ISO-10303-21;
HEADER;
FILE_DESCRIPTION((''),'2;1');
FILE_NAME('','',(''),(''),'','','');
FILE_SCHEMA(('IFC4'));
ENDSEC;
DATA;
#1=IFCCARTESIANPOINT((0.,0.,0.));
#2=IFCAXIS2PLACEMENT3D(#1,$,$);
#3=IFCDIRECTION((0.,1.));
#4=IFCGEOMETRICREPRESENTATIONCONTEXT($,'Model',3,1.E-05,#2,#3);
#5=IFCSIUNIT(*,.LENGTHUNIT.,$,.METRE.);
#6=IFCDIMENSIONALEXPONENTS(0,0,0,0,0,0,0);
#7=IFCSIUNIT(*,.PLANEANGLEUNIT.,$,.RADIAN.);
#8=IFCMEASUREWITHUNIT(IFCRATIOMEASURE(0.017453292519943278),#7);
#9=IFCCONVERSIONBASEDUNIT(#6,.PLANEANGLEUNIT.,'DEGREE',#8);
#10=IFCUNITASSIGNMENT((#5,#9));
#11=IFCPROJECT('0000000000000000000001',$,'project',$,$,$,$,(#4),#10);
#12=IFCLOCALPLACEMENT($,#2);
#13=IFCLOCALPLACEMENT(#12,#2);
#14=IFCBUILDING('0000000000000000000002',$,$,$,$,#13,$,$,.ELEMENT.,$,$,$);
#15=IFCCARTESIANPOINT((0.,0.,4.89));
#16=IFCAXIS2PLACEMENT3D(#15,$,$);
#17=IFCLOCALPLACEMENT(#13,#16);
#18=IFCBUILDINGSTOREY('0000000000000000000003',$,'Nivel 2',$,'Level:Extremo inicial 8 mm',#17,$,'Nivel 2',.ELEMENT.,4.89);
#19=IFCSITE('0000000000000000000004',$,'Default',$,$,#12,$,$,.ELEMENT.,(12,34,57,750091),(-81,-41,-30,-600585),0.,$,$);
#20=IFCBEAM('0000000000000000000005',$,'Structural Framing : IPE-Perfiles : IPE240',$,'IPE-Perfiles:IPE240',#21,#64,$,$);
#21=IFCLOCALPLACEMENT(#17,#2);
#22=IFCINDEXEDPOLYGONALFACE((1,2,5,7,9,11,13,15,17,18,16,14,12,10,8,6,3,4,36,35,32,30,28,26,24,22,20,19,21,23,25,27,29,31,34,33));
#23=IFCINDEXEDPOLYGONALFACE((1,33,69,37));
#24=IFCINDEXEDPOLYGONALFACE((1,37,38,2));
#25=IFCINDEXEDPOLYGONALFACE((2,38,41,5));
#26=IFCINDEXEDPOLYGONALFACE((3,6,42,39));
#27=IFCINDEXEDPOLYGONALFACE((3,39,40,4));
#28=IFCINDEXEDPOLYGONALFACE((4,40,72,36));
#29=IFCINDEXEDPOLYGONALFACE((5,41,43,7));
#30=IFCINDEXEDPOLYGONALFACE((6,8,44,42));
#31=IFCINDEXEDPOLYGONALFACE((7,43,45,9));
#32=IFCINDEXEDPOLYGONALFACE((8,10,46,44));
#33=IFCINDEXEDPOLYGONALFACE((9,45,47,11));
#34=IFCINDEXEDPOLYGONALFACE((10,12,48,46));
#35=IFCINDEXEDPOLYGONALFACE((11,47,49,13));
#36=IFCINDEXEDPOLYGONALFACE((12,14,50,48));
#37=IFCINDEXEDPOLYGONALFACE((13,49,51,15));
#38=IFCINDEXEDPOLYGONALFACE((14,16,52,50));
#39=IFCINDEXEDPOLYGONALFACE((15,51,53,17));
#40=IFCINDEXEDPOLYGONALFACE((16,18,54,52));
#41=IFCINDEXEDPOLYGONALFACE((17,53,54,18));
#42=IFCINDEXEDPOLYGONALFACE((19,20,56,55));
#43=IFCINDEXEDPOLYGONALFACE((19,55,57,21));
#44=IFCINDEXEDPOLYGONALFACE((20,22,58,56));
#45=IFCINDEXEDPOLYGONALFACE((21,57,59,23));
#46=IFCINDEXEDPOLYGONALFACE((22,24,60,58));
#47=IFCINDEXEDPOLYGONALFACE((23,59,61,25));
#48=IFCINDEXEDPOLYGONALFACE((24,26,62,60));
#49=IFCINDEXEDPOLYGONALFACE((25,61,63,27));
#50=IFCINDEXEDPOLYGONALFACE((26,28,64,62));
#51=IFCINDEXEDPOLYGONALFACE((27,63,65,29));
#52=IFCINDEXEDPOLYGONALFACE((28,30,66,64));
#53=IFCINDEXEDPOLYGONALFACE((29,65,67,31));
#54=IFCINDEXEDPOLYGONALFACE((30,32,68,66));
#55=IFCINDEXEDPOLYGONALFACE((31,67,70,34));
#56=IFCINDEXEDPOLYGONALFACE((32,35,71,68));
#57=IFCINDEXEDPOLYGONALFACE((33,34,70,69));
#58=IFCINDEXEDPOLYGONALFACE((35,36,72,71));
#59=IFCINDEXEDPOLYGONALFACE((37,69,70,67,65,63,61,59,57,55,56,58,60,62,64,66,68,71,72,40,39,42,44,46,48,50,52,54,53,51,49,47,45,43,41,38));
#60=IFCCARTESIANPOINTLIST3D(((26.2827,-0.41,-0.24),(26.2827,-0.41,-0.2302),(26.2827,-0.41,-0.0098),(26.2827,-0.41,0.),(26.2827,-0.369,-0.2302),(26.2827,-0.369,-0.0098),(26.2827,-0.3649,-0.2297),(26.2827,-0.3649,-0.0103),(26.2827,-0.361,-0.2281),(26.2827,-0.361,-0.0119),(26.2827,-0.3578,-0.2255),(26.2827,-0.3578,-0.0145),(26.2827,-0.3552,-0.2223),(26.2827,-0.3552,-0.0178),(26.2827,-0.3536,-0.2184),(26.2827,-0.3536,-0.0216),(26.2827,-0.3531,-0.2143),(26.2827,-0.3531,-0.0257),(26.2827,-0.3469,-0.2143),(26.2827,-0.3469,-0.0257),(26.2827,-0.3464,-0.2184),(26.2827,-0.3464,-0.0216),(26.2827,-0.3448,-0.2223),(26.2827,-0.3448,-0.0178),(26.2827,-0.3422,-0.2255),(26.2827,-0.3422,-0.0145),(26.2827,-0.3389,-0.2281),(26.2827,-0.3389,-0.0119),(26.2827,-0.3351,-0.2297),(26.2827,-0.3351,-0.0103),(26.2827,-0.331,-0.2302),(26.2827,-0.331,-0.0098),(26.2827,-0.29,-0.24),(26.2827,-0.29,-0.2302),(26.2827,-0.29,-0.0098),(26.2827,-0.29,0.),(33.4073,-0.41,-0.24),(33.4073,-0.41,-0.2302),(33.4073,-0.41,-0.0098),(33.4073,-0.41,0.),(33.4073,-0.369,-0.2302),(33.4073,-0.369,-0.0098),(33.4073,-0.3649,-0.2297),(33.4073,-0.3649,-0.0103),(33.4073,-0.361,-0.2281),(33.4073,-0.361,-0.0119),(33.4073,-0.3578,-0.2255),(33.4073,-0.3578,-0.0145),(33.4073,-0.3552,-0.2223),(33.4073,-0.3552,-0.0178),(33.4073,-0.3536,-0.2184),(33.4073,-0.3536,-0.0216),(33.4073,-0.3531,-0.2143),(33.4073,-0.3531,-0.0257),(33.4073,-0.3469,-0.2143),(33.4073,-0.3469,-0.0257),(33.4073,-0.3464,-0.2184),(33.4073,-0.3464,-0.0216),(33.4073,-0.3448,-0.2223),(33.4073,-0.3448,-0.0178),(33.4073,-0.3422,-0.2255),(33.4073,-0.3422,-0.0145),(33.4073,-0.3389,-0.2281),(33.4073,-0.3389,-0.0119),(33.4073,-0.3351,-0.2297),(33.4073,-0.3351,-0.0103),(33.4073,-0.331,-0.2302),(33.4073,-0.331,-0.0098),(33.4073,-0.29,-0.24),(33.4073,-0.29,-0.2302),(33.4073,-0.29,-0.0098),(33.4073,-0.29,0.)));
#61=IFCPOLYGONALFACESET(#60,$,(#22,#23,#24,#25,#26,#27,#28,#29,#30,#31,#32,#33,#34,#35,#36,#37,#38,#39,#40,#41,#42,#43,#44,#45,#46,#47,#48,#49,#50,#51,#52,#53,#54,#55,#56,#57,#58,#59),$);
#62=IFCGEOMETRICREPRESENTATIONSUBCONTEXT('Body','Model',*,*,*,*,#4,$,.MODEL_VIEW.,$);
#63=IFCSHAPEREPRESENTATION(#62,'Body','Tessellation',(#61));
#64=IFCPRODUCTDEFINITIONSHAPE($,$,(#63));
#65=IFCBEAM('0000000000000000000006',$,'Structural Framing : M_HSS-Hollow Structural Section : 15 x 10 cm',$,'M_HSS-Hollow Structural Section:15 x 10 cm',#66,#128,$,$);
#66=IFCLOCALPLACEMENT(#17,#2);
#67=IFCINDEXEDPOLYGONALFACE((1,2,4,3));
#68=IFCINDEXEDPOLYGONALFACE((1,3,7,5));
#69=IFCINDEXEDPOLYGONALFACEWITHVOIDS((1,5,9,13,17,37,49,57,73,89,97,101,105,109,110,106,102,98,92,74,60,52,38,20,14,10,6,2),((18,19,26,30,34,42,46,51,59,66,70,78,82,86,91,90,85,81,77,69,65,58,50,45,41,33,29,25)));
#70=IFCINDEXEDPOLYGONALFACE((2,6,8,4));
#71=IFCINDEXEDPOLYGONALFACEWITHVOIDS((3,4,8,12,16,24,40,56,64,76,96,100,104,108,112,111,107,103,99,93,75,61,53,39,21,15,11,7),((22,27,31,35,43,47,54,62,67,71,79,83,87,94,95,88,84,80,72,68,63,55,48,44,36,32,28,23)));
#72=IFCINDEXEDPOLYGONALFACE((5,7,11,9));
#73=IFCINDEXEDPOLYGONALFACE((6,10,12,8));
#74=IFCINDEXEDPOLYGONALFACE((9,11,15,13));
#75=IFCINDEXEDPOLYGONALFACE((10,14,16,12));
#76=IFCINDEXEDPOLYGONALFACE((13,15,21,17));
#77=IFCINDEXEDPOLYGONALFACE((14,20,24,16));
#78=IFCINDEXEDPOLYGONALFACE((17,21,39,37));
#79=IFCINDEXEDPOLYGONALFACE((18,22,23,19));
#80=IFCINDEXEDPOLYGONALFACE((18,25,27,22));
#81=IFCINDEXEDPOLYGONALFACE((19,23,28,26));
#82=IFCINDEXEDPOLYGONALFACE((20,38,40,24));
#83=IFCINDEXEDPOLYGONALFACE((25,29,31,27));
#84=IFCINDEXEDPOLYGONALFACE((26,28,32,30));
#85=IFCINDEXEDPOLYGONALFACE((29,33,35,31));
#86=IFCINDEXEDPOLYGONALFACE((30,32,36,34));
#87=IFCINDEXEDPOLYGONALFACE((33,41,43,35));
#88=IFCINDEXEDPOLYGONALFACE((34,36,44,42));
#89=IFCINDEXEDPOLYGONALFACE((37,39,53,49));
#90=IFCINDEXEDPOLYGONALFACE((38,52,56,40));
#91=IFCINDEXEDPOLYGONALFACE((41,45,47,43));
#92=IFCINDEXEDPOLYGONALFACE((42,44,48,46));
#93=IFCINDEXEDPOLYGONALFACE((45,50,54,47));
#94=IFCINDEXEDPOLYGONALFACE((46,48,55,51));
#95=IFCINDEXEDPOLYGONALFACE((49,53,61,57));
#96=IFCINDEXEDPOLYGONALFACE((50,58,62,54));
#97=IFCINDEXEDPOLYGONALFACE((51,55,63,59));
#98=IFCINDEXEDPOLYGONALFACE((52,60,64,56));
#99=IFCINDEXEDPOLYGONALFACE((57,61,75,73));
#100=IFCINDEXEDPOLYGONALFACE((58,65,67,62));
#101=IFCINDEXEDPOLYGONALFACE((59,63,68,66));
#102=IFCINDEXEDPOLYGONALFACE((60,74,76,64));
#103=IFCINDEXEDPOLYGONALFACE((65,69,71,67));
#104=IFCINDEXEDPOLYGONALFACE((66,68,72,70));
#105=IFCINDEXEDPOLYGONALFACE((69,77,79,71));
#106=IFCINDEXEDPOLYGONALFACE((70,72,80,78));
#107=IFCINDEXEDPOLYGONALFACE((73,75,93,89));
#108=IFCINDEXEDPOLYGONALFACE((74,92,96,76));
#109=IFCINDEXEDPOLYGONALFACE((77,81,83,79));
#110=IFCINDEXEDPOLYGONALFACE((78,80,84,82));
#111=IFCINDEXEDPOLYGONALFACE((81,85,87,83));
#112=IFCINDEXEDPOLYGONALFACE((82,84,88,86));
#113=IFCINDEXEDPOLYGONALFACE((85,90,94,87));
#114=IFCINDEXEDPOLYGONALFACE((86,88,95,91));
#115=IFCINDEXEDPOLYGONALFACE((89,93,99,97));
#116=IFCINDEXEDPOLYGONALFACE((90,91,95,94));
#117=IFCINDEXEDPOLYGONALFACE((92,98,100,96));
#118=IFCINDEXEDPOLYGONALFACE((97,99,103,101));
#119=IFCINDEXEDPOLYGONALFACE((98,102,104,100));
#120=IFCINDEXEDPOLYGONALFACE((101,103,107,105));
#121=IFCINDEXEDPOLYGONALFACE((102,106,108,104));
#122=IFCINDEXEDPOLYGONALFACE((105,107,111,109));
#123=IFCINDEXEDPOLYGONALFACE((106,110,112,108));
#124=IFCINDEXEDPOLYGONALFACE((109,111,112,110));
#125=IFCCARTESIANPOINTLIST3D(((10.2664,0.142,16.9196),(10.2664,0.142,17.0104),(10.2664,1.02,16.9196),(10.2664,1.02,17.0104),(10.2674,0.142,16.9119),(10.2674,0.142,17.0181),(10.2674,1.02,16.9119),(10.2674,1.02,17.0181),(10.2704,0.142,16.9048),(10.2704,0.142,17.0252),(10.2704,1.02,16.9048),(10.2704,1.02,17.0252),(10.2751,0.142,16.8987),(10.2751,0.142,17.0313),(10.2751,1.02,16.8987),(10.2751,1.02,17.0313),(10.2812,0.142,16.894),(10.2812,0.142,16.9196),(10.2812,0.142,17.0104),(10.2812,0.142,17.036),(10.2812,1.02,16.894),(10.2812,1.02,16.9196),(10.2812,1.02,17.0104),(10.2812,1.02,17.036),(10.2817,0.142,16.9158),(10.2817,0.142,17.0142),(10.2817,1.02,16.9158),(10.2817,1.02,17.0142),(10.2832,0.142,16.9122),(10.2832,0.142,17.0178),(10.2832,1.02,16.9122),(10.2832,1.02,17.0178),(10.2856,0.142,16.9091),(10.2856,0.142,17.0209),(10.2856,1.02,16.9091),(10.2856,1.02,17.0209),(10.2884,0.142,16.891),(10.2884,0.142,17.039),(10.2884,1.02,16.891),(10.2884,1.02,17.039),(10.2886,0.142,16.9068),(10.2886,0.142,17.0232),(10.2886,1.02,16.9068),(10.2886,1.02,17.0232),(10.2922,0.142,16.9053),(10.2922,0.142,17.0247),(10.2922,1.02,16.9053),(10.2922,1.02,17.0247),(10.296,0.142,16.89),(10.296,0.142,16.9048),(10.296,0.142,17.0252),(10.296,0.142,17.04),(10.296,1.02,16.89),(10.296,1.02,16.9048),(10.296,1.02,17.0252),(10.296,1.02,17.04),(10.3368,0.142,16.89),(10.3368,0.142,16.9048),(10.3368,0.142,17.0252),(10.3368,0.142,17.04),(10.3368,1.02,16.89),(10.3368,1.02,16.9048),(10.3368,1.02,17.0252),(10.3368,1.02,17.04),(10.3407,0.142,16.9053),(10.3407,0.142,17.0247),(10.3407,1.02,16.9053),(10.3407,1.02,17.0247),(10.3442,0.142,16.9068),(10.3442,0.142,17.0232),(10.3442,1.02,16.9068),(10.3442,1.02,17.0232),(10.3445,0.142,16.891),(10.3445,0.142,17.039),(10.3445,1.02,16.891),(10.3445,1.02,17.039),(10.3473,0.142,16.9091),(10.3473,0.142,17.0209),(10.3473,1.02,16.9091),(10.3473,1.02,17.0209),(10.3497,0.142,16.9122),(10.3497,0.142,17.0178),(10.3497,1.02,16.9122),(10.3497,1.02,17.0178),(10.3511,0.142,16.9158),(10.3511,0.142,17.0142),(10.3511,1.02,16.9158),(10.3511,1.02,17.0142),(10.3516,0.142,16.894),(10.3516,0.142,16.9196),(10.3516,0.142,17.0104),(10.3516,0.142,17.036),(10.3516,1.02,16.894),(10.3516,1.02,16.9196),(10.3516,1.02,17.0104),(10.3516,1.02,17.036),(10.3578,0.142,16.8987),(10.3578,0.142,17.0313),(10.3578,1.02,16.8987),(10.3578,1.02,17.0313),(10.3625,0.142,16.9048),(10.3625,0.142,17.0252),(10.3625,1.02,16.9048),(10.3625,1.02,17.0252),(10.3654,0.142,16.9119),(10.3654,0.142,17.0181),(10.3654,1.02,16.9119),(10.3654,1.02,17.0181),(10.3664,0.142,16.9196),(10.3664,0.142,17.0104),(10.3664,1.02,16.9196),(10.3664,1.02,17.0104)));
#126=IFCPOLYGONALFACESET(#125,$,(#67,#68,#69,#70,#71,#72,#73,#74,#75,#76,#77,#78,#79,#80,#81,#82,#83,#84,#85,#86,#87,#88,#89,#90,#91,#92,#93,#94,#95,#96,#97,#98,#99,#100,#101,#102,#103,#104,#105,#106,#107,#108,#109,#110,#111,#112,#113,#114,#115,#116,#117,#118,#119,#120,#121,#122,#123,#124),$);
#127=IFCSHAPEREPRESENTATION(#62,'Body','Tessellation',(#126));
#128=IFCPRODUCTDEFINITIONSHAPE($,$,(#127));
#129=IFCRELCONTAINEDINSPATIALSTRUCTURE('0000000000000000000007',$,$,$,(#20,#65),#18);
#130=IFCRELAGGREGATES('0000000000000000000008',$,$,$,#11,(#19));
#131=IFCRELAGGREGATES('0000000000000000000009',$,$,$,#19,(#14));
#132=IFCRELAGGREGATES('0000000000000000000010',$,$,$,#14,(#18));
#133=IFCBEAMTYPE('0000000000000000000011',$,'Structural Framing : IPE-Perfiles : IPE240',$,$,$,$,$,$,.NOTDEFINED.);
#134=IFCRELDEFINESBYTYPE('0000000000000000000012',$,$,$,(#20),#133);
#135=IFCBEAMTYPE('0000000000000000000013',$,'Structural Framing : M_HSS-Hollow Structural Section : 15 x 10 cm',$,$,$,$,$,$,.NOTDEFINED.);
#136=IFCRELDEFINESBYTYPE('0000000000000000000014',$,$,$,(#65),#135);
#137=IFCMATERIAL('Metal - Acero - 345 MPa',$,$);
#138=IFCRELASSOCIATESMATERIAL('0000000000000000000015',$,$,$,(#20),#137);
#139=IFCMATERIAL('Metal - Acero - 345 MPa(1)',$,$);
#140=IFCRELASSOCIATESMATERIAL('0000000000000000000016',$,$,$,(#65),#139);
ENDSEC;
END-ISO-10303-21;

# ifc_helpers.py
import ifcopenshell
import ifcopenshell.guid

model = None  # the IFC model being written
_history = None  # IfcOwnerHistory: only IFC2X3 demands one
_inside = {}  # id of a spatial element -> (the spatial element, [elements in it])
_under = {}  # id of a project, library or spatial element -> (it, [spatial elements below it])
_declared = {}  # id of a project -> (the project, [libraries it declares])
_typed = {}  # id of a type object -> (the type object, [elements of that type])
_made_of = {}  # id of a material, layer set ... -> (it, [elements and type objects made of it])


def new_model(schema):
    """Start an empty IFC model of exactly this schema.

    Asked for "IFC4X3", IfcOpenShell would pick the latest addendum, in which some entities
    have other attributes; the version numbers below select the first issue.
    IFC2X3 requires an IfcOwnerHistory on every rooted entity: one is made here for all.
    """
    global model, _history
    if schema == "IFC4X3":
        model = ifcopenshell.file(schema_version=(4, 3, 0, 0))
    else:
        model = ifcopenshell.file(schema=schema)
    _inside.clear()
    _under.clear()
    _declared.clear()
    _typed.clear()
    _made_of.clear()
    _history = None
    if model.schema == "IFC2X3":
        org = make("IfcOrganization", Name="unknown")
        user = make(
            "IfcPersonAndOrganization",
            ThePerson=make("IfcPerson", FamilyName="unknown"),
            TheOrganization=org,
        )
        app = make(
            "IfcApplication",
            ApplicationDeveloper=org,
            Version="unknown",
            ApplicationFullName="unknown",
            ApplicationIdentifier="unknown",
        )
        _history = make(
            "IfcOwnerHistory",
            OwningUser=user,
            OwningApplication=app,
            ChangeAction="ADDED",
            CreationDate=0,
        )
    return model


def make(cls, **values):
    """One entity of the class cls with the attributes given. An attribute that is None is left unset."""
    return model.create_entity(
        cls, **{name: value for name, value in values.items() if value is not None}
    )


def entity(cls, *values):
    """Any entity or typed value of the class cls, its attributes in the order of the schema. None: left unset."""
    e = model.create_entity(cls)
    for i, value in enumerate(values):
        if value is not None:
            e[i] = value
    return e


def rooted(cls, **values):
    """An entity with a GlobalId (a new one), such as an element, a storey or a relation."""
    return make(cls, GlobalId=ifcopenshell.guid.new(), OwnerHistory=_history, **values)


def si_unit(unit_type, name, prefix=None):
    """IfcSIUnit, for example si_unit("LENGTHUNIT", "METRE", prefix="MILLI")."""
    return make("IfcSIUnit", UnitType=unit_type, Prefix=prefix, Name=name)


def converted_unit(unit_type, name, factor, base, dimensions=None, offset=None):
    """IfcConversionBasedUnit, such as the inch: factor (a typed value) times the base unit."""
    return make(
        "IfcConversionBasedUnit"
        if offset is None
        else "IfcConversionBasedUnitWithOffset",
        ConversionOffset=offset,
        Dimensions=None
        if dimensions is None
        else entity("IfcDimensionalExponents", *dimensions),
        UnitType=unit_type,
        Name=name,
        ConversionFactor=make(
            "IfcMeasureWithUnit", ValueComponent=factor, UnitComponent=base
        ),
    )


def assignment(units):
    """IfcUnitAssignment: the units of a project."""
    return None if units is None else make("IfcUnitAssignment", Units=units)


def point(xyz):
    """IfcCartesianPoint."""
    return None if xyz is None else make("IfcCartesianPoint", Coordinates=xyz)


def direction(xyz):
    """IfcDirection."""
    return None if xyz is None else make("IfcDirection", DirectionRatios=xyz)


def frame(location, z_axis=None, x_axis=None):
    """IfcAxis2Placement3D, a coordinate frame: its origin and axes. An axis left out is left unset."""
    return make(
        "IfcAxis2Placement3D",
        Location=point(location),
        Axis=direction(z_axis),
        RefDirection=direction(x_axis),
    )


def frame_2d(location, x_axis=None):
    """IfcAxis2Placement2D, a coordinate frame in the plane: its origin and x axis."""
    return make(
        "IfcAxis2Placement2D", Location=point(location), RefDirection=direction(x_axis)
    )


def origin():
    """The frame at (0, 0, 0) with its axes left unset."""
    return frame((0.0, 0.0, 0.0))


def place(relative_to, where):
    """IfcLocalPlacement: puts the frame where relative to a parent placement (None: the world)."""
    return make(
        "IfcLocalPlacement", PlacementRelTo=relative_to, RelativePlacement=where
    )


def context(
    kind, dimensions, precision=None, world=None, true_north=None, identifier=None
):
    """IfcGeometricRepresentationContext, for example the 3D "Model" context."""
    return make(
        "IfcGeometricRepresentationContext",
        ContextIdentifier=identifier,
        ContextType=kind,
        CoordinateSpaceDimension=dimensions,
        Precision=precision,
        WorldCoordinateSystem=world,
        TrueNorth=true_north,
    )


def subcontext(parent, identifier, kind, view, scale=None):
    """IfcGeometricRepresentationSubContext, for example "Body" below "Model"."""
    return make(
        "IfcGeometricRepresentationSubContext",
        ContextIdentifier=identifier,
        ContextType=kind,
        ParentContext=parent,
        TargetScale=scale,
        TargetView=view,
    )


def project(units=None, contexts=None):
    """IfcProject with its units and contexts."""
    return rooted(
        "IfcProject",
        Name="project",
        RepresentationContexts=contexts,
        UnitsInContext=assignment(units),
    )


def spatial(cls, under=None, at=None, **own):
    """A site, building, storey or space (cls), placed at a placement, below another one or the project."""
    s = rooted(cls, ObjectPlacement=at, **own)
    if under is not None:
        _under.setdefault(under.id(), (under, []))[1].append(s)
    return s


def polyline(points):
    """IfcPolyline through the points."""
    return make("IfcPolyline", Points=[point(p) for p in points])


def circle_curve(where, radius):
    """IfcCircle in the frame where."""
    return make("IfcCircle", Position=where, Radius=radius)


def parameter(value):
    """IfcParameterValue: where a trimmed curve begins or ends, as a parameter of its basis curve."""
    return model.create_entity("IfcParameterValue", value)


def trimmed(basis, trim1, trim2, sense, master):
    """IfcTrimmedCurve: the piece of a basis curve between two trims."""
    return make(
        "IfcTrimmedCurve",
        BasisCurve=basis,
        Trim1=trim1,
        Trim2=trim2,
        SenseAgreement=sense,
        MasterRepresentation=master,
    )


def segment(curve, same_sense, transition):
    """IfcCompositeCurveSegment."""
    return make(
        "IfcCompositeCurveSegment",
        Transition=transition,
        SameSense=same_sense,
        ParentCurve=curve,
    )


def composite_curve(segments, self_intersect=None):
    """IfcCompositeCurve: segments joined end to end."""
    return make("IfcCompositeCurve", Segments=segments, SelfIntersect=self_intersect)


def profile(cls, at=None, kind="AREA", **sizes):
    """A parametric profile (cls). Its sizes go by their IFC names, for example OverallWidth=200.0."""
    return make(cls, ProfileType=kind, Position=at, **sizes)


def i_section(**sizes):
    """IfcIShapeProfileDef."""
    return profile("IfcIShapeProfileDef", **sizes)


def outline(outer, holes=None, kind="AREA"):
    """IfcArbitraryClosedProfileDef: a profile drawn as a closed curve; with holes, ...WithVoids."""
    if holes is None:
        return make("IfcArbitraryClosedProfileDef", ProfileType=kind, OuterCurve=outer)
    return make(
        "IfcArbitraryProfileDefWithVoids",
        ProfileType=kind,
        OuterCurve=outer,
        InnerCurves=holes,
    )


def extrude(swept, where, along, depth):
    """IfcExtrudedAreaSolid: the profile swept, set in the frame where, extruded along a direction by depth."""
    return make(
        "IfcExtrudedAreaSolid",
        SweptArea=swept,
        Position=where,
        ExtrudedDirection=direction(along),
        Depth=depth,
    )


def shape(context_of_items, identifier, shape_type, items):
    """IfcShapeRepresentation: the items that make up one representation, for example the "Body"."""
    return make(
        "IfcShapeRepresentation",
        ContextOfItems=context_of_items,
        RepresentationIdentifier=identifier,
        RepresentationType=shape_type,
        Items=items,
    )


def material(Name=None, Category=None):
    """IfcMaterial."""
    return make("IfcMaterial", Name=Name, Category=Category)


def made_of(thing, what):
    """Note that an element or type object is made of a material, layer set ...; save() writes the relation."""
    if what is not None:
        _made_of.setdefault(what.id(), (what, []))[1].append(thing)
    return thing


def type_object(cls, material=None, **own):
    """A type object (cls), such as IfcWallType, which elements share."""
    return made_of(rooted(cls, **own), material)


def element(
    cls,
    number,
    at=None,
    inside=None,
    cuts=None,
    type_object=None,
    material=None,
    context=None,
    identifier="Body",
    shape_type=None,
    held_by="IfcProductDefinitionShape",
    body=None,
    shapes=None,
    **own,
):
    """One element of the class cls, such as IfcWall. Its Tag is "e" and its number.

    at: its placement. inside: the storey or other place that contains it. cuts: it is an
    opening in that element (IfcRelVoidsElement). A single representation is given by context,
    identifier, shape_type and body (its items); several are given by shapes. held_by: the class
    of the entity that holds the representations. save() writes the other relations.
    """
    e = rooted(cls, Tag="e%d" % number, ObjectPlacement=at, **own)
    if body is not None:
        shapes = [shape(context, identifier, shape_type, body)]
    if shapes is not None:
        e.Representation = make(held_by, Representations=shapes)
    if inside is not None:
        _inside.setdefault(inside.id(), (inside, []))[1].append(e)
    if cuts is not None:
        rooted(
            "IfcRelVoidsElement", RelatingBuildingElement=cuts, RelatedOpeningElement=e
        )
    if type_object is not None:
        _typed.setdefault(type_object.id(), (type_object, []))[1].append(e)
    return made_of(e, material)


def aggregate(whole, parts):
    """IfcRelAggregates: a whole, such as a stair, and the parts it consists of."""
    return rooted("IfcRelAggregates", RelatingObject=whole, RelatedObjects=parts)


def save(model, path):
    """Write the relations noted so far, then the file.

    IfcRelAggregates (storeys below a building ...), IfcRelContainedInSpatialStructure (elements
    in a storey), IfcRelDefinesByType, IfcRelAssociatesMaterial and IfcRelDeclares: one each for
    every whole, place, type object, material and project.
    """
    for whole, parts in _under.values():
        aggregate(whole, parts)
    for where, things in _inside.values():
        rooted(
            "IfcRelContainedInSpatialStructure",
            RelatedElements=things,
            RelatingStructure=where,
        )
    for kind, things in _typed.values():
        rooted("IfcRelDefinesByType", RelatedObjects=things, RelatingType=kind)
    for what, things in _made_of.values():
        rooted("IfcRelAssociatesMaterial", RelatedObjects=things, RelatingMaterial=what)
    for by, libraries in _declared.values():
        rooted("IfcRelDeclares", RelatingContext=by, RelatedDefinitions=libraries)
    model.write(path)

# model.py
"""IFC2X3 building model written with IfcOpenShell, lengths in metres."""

from ifc_helpers import new_model, entity, si_unit, converted_unit, direction, frame, frame_2d, origin, place, context, subcontext, project, spatial, polyline, circle_curve, parameter, trimmed, segment, composite_curve, i_section, outline, extrude, material, type_object, element, save


model = new_model("IFC2X3")

# Units and contexts
model_context = context("Model", 3, precision=1e-05, world=origin(), true_north=direction((0.0, 1.0)))
body_context = subcontext(model_context, "Body", "Model", "MODEL_VIEW")
ifc_project = project(units=[si_unit("LENGTHUNIT", "METRE"), converted_unit("PLANEANGLEUNIT", "DEGREE", entity("IfcRatioMeasure", 0.017453292519943278), si_unit("PLANEANGLEUNIT", "RADIAN"), dimensions=[0, 0, 0, 0, 0, 0, 0])], contexts=[model_context])

# Site, building, storey
site_placement = place(None, origin())
site = spatial("IfcSite", under=ifc_project, at=site_placement, Name="Default", CompositionType="ELEMENT", RefLatitude=(12, 34, 57, 750091), RefLongitude=(-81, -41, -30, -600585), RefElevation=0.0)
building_placement = place(site_placement, origin())
building = spatial("IfcBuilding", under=site, at=building_placement, CompositionType="ELEMENT")
storey_placement = place(building_placement, frame((0.0, 0.0, 4.89)))
storey = spatial("IfcBuildingStorey", under=building, at=storey_placement, Name="Nivel 2", ObjectType="Level:Extremo inicial 8 mm", LongName="Nivel 2", CompositionType="ELEMENT", Elevation=4.89)

# Shared definitions
ifc_material_1 = material(Name="Metal - Acero - 345 MPa")

# Beams
beam_type_1 = type_object("IfcBeamType", Name="Structural Framing : IPE-Perfiles : IPE240", PredefinedType="NOTDEFINED")
beam_1_placement = place(storey_placement, frame((26.195, -0.35, 0.0)))
element("IfcBeam", 1, at=beam_1_placement, inside=storey, type_object=beam_type_1, material=ifc_material_1, Name="Structural Framing : IPE-Perfiles : IPE240", ObjectType="IPE-Perfiles:IPE240", context=body_context, shape_type="SweptSolid", body=[
    extrude(i_section(OverallWidth=0.12, OverallDepth=0.24, WebThickness=0.0062, FlangeThickness=0.0098, FilletRadius=0.0159, at=frame_2d((0.0, 0.0), x_axis=(0.0, 1.0))), frame((0.0877, 0.0, -0.12), z_axis=(1.0, 0.0, 0.0), x_axis=(0.0, 0.0, -1.0)), (0.0, 0.0, 1.0), 7.1246),
])
ifc_material_2 = material(Name="Metal - Acero - 345 MPa(1)")
beam_type_2 = type_object("IfcBeamType", Name="Structural Framing : M_HSS-Hollow Structural Section : 15 x 10 cm", PredefinedType="NOTDEFINED")
beam_2_placement = place(storey_placement, frame((10.3164, 0.8821, 17.04), z_axis=(0.0, 0.0, 1.0), x_axis=(0.0, -1.0, 0.0)))
element("IfcBeam", 2, at=beam_2_placement, inside=storey, type_object=beam_type_2, material=ifc_material_2, Name="Structural Framing : M_HSS-Hollow Structural Section : 15 x 10 cm", ObjectType="M_HSS-Hollow Structural Section:15 x 10 cm", context=body_context, shape_type="SweptSolid", body=[
    extrude(outline(composite_curve([segment(trimmed(circle_curve(frame_2d((-0.0204, -0.0454), x_axis=(1.0, 0.0)), 0.0296), [parameter(180.0)], [parameter(270.0)], True, "PARAMETER"), True, "CONTINUOUS"), segment(polyline([(-0.0204, -0.075), (0.0204, -0.075)]), True, "CONTINUOUS"), segment(trimmed(circle_curve(frame_2d((0.0204, -0.0454), x_axis=(1.0, 0.0)), 0.0296), [parameter(270.0)], [parameter(0.0)], True, "PARAMETER"), True, "CONTINUOUS"), segment(polyline([(0.05, -0.0454), (0.05, 0.0454)]), True, "CONTINUOUS"), segment(trimmed(circle_curve(frame_2d((0.0204, 0.0454), x_axis=(1.0, 0.0)), 0.0296), [parameter(360.0)], [parameter(90.0)], True, "PARAMETER"), True, "CONTINUOUS"), segment(polyline([(0.0204, 0.075), (-0.0204, 0.075)]), True, "CONTINUOUS"), segment(trimmed(circle_curve(frame_2d((-0.0204, 0.0454), x_axis=(1.0, 0.0)), 0.0296), [parameter(90.0)], [parameter(180.0)], True, "PARAMETER"), True, "CONTINUOUS"), segment(polyline([(-0.05, 0.0454), (-0.05, -0.0454)]), True, "CONTINUOUS")], self_intersect=False), holes=[composite_curve([segment(polyline([(0.0204, -0.0602), (-0.0204, -0.0602)]), True, "CONTINUOUS"), segment(trimmed(circle_curve(frame_2d((-0.0204, -0.0454), x_axis=(1.0, 0.0)), 0.0148), [parameter(180.0)], [parameter(270.0)], True, "PARAMETER"), False, "CONTINUOUS"), segment(polyline([(-0.0352, -0.0454), (-0.0352, 0.0454)]), True, "CONTINUOUS"), segment(trimmed(circle_curve(frame_2d((-0.0204, 0.0454), x_axis=(1.0, 0.0)), 0.0148), [parameter(90.0)], [parameter(180.0)], True, "PARAMETER"), False, "CONTINUOUS"), segment(polyline([(-0.0204, 0.0602), (0.0204, 0.0602)]), True, "CONTINUOUS"), segment(trimmed(circle_curve(frame_2d((0.0204, 0.0454), x_axis=(1.0, 0.0)), 0.0148), [parameter(0.0)], [parameter(90.0)], True, "PARAMETER"), False, "CONTINUOUS"), segment(polyline([(0.0352, 0.0454), (0.0352, -0.0454)]), True, "CONTINUOUS"), segment(trimmed(circle_curve(frame_2d((0.0204, -0.0454), x_axis=(1.0, 0.0)), 0.0148), [parameter(270.0)], [parameter(0.0)], True, "PARAMETER"), False, "CONTINUOUS")], self_intersect=False)]), frame((-0.1379, 0.0, -0.075), z_axis=(1.0, 0.0, 0.0), x_axis=(0.0, -1.0, 0.0)), (0.0, 0.0, 1.0), 0.878),
])

save(model, "model.ifc")
